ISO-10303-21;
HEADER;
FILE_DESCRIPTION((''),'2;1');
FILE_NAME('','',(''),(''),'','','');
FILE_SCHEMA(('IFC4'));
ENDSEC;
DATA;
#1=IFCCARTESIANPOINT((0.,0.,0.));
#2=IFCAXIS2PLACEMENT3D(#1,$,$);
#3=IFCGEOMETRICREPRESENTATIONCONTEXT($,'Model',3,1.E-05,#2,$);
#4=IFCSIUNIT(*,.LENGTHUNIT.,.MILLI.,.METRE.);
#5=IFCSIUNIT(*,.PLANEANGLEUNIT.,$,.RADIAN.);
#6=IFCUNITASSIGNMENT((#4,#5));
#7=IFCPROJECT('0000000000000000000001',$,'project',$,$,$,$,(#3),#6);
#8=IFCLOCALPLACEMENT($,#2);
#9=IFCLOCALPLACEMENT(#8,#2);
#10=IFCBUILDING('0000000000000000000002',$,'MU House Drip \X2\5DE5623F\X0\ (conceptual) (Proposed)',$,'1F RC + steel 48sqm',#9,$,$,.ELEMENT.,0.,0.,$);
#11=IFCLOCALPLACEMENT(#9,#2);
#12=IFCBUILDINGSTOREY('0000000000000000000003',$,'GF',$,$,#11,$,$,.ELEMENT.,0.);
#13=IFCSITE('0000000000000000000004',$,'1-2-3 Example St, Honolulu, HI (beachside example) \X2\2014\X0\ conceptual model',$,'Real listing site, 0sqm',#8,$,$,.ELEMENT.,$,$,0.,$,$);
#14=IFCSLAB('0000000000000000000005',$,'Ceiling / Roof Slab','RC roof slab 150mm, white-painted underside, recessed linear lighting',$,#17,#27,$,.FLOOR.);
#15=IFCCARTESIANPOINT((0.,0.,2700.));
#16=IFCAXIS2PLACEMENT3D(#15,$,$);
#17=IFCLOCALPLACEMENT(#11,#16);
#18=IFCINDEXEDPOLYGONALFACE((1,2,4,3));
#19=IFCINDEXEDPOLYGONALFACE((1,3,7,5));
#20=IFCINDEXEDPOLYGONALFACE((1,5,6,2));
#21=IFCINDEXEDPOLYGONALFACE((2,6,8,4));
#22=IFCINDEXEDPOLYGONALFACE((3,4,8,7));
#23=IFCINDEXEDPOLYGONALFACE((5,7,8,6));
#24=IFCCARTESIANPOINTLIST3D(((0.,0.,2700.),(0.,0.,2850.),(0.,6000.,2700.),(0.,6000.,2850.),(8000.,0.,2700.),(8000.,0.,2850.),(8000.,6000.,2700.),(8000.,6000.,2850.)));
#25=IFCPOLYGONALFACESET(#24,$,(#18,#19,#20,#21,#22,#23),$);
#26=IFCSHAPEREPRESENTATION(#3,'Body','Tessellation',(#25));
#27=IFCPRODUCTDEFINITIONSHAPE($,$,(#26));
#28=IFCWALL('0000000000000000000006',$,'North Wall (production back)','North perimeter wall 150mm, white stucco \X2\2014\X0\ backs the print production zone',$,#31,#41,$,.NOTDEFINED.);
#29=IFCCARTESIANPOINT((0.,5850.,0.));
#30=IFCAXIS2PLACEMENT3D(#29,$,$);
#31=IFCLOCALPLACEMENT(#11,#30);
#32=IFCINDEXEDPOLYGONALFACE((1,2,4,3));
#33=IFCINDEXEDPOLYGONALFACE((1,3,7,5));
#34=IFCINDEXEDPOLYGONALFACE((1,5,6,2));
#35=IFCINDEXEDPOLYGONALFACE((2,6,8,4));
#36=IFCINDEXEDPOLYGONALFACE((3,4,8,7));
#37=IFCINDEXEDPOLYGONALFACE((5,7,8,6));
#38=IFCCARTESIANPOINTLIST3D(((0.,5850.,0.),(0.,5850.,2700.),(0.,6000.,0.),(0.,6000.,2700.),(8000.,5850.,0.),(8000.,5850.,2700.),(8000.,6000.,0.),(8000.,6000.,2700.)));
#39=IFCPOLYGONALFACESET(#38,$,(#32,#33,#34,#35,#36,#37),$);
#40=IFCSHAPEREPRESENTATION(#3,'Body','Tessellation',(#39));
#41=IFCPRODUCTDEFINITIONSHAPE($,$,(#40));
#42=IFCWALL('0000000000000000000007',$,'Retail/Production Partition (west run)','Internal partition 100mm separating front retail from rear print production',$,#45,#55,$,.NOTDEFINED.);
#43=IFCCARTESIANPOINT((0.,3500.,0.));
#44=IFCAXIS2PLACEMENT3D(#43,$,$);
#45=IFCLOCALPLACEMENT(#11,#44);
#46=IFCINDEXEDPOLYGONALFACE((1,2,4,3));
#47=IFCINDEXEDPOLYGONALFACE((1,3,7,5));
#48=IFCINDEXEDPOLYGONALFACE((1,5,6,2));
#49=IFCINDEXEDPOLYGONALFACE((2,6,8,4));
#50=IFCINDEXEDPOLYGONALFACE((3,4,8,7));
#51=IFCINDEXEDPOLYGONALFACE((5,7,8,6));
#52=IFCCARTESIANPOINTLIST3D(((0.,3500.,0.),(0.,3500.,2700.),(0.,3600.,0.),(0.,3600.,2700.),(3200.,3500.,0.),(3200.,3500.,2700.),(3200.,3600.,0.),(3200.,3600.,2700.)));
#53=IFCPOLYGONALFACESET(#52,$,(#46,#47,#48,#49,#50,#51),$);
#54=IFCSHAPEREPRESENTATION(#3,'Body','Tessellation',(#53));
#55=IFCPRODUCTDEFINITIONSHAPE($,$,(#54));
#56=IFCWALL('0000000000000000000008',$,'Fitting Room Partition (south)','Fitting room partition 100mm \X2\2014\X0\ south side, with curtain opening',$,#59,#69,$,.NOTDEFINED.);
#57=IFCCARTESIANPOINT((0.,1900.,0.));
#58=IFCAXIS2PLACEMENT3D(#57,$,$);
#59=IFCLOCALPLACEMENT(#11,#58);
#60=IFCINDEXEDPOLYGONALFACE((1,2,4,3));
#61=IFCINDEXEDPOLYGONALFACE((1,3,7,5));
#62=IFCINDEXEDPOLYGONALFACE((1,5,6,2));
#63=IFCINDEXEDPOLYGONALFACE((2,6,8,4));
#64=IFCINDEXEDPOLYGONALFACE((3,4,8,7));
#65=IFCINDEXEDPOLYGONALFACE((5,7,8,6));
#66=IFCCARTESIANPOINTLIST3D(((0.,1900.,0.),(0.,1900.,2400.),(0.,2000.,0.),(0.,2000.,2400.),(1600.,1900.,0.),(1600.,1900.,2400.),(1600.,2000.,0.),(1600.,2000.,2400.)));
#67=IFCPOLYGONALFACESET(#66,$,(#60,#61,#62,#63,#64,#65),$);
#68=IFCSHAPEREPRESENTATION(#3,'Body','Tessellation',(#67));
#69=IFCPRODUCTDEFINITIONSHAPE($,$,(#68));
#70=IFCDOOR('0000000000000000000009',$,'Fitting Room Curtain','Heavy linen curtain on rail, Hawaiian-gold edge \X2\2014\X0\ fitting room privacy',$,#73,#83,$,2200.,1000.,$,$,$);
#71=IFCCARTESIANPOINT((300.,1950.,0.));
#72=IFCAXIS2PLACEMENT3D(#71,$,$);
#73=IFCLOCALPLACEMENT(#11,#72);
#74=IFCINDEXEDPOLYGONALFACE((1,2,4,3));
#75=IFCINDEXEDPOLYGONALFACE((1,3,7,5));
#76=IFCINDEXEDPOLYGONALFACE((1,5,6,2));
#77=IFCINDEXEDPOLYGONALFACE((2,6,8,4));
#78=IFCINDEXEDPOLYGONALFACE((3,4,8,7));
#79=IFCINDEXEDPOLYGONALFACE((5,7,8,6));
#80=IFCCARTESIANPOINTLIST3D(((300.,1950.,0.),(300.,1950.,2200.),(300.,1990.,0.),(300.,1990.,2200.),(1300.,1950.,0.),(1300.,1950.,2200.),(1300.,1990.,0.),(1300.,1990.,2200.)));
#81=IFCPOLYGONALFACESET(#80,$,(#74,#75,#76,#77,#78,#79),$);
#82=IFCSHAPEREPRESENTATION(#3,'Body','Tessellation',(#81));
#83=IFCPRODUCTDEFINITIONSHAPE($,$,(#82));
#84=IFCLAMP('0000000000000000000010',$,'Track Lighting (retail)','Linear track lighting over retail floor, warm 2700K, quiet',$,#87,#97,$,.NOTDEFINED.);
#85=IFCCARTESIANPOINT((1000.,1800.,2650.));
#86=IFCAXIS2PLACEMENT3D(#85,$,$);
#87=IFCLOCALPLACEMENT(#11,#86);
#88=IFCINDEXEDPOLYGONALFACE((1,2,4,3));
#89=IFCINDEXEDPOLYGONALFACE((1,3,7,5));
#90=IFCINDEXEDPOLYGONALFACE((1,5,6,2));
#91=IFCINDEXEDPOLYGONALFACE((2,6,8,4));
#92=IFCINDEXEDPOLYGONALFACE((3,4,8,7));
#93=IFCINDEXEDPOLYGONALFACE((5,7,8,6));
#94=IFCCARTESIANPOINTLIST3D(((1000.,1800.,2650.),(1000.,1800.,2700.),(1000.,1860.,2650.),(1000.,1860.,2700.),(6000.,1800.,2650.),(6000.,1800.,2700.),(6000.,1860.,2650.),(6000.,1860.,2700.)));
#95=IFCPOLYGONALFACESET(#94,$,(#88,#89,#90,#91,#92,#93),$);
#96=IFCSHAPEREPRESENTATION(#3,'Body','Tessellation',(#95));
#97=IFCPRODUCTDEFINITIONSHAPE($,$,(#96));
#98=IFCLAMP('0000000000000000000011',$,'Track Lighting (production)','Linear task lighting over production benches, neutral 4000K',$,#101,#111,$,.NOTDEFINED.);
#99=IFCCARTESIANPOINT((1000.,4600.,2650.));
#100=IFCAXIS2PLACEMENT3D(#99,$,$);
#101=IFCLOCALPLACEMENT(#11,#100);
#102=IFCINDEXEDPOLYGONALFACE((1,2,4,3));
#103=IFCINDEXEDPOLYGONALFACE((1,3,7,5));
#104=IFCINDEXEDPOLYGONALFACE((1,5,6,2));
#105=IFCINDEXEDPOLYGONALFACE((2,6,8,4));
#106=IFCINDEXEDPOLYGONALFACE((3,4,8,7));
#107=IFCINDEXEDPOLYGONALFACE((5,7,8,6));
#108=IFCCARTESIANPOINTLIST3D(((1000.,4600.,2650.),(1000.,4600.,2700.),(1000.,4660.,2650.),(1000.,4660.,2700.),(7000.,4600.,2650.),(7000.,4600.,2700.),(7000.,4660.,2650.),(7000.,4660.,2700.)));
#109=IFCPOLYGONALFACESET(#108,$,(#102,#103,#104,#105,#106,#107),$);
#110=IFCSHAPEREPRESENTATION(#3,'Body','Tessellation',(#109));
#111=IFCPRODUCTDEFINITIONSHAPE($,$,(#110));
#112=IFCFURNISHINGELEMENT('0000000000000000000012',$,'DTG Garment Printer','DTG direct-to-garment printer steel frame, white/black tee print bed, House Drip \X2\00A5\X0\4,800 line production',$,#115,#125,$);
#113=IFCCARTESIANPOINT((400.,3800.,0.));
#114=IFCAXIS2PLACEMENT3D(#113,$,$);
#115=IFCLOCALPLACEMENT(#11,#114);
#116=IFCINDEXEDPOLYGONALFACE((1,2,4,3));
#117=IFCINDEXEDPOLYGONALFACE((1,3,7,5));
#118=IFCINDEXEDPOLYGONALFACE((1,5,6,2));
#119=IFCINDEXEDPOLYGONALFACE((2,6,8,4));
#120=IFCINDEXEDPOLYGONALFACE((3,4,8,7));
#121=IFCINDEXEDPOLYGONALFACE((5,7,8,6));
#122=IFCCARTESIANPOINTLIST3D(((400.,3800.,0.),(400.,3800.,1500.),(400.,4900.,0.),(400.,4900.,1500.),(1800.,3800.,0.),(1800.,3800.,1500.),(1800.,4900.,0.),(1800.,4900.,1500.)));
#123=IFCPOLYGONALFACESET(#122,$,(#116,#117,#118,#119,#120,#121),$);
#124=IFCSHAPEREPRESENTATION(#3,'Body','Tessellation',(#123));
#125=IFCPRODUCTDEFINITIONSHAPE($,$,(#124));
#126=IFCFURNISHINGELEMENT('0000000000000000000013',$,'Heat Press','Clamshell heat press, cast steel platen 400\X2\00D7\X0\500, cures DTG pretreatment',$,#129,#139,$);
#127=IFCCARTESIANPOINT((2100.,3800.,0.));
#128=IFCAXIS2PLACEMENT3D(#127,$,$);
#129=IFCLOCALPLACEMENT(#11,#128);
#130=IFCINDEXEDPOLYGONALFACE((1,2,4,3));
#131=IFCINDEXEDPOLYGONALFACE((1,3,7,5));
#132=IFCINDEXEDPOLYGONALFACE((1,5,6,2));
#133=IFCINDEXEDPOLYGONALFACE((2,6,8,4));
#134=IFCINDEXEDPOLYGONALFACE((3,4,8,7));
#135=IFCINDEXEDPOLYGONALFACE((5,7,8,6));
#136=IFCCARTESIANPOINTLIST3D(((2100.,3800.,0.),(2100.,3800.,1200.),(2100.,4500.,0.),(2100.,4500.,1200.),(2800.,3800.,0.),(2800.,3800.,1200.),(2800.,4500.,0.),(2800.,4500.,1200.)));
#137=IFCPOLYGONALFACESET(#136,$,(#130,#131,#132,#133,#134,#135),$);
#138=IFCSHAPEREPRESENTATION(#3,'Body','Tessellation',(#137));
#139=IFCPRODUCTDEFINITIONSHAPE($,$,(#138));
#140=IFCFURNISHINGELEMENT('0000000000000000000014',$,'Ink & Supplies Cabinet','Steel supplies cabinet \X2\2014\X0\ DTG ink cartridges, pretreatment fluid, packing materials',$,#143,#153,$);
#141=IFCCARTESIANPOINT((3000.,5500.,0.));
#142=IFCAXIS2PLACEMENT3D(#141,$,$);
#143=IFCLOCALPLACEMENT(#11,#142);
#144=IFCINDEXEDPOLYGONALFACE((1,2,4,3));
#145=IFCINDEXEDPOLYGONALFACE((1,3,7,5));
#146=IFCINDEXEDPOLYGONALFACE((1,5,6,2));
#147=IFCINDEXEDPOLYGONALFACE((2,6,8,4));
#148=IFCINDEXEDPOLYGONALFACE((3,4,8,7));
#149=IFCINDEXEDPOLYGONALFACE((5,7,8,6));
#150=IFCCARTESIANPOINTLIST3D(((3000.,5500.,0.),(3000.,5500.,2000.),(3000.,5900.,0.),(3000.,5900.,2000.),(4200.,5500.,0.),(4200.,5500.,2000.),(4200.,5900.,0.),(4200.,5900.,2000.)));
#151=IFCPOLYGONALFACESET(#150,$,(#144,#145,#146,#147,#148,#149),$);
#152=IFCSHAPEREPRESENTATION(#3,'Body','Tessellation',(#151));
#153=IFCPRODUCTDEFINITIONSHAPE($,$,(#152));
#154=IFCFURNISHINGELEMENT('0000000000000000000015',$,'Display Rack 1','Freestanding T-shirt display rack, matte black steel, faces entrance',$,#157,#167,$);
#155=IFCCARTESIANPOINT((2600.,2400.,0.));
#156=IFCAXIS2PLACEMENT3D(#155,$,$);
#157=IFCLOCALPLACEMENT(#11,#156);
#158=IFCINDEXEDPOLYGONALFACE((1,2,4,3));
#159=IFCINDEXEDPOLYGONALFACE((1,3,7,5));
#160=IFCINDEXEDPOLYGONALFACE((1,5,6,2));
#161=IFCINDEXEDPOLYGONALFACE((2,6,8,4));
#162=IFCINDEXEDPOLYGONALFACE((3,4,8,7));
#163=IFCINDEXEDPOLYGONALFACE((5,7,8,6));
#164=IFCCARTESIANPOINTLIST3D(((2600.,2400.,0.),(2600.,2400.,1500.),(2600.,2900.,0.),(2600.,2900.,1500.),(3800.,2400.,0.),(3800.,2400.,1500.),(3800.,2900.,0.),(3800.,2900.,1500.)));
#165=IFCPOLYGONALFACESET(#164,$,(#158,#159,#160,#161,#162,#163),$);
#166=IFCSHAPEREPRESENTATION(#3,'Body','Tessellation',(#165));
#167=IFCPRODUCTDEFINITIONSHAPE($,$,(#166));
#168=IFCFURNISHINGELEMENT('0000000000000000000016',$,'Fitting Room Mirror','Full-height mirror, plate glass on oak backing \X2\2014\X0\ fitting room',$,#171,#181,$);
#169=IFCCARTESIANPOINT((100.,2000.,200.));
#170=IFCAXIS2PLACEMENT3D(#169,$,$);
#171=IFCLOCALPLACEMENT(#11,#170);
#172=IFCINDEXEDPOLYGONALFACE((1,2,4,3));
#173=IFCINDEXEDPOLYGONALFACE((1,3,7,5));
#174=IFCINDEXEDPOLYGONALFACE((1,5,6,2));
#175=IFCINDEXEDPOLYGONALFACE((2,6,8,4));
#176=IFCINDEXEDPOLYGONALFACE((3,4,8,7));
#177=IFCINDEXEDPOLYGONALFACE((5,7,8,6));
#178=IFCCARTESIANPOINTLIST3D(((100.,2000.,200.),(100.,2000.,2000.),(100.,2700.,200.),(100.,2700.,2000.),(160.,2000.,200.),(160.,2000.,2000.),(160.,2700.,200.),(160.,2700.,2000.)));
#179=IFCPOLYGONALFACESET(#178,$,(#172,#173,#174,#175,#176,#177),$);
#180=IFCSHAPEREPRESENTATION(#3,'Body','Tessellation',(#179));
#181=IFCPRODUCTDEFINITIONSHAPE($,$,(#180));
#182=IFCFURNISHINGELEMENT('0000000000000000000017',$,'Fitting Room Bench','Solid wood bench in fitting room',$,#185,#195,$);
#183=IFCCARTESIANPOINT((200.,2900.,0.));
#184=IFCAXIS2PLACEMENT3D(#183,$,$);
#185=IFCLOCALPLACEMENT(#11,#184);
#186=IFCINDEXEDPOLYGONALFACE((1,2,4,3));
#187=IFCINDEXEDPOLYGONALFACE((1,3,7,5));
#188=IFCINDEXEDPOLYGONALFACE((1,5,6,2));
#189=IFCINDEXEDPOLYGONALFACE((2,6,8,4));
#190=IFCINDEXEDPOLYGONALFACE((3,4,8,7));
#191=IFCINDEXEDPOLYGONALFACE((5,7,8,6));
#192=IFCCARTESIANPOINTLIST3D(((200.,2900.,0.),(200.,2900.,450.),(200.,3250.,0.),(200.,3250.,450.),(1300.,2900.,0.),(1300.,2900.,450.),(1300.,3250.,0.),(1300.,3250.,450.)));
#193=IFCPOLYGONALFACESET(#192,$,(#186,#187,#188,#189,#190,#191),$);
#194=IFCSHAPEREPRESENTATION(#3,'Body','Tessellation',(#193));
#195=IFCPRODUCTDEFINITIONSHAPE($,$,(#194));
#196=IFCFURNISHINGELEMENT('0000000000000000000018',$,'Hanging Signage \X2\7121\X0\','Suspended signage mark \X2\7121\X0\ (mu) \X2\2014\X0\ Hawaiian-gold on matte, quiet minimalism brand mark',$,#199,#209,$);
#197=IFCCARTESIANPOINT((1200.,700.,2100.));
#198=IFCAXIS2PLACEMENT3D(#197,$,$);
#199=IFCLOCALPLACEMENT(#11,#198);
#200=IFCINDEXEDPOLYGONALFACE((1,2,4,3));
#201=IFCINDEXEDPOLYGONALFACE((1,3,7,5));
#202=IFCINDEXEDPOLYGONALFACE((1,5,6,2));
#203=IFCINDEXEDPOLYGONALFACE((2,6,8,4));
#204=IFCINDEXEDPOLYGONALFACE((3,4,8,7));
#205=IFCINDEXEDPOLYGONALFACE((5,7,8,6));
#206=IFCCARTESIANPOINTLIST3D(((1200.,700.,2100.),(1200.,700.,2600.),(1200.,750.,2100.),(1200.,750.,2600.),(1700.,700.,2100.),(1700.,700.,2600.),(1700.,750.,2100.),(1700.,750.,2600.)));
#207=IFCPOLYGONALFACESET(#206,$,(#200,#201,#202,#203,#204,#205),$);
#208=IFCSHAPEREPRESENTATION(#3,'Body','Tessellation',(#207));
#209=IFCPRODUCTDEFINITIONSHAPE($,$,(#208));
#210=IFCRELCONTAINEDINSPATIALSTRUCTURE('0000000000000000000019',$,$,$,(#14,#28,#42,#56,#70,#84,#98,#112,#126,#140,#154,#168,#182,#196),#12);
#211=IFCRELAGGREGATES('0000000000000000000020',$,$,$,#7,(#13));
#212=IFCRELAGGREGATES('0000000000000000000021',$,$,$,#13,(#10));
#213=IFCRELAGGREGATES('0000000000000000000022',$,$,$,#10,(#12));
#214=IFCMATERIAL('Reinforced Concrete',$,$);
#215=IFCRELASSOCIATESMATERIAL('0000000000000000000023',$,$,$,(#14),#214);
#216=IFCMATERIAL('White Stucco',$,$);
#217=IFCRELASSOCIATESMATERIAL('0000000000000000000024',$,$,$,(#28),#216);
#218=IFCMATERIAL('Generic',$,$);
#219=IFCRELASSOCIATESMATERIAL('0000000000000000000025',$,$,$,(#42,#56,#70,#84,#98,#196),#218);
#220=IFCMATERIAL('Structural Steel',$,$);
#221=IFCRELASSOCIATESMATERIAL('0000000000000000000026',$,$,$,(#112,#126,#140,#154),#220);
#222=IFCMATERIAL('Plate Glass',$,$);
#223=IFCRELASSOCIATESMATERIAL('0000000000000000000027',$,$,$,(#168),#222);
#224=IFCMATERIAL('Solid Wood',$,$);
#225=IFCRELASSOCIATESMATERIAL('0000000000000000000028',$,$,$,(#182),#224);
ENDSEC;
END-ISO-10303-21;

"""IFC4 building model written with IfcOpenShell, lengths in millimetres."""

from ifc_helpers import new_model, si_unit, frame, frame_2d, origin, place, context, project, spatial, rectangle, extrude, material, element, fill, save


model = new_model("IFC4")

# Units and contexts
model_context = context("Model", 3, precision=1e-05, world=origin())
ifc_project = project(units=[si_unit("LENGTHUNIT", "METRE", prefix="MILLI"), si_unit("PLANEANGLEUNIT", "RADIAN")], contexts=[model_context])

# Site, building, storey
site_placement = place(None, origin())
site = spatial("IfcSite", under=ifc_project, at=site_placement, Name="1-2-3 Example St, Honolulu, HI (beachside example) — conceptual model", ObjectType="Real listing site, 0sqm", CompositionType="ELEMENT", RefElevation=0.0)
building_placement = place(site_placement, origin())
building = spatial("IfcBuilding", under=site, at=building_placement, Name="MU House Drip 工房 (conceptual) (Proposed)", ObjectType="1F RC + steel 48sqm", CompositionType="ELEMENT", ElevationOfRefHeight=0.0, ElevationOfTerrain=0.0)
storey_placement = place(building_placement, origin())
storey = spatial("IfcBuildingStorey", under=building, at=storey_placement, Name="GF", CompositionType="ELEMENT", Elevation=0.0)

# Slab
ifc_material_1 = material(Name="Reinforced Concrete")
slab_1_placement = place(storey_placement, frame((0.0, 0.0, 2700.0)))
element("IfcSlab", 1, at=slab_1_placement, inside=storey, material=ifc_material_1, Name="Ceiling / Roof Slab", Description="RC roof slab 150mm, white-painted underside, recessed linear lighting", PredefinedType="FLOOR", context=model_context, shape_type="SweptSolid", body=[
    extrude(rectangle(XDim=8000.0, YDim=6000.0, at=frame_2d((4000.0, 3000.0))), frame((0.0, 0.0, 2700.0)), (0.0, 0.0, 1.0), 150.0),
])

# Shared definitions
ifc_material_2 = material(Name="White Stucco")
ifc_material_3 = material(Name="Plate Glass")

# Walls
wall_1_placement = place(storey_placement, frame((0.0, 5850.0, 0.0)))
element("IfcWall", 2, at=wall_1_placement, inside=storey, material=ifc_material_2, Name="North Wall (production back)", Description="North perimeter wall 150mm, white stucco — backs the print production zone", PredefinedType="NOTDEFINED", context=model_context, shape_type="SweptSolid", body=[
    extrude(rectangle(XDim=8000.0, YDim=150.0, at=frame_2d((4000.0, 75.0))), frame((0.0, 5850.0, 0.0)), (0.0, 0.0, 1.0), 2700.0),
])
ifc_material_4 = material(Name="Generic")
wall_2_placement = place(storey_placement, frame((0.0, 3500.0, 0.0)))
element("IfcWall", 3, at=wall_2_placement, inside=storey, material=ifc_material_4, Name="Retail/Production Partition (west run)", Description="Internal partition 100mm separating front retail from rear print production", PredefinedType="NOTDEFINED", context=model_context, shape_type="SweptSolid", body=[
    extrude(rectangle(XDim=3200.0, YDim=100.0, at=frame_2d((1600.0, 50.0))), frame((0.0, 3500.0, 0.0)), (0.0, 0.0, 1.0), 2700.0),
])

# Wall, opening, door
wall_3_placement = place(storey_placement, frame((0.0, 1900.0, 0.0)))
wall_3 = element("IfcWall", 4, at=wall_3_placement, inside=storey, material=ifc_material_4, Name="Fitting Room Partition (south)", Description="Fitting room partition 100mm — south side, with curtain opening", PredefinedType="NOTDEFINED", context=model_context, shape_type="SweptSolid", body=[
    extrude(rectangle(XDim=1600.0, YDim=100.0, at=frame_2d((800.0, 50.0))), frame((0.0, 1900.0, 0.0)), (0.0, 0.0, 1.0), 2400.0),
])
opening_1_placement = place(storey_placement, frame((300.0, 1950.0, 0.0)))
opening_1 = element("IfcOpeningElement", 5, at=opening_1_placement, cuts=wall_3, PredefinedType="NOTDEFINED", context=model_context, shape_type="SweptSolid", body=[
    extrude(rectangle(XDim=1000.0, YDim=40.0, at=frame_2d((500.0, 20.0))), frame((300.0, 1950.0, 0.0)), (0.0, 0.0, 1.0), 2200.0),
])
door_1_placement = place(storey_placement, frame((300.0, 1950.0, 0.0)))
door_1 = element("IfcDoor", 6, at=door_1_placement, inside=storey, material=ifc_material_4, Name="Fitting Room Curtain", Description="Heavy linen curtain on rail, Hawaiian-gold edge — fitting room privacy", OverallHeight=2200.0, OverallWidth=1000.0, context=model_context, shape_type="SweptSolid", body=[
    extrude(rectangle(XDim=1000.0, YDim=40.0, at=frame_2d((500.0, 20.0))), frame((300.0, 1950.0, 0.0)), (0.0, 0.0, 1.0), 2200.0),
])
fill(opening_1, door_1)

# Lamps
lamp_1_placement = place(storey_placement, frame((1000.0, 1800.0, 2650.0)))
element("IfcLamp", 7, at=lamp_1_placement, inside=storey, material=ifc_material_4, Name="Track Lighting (retail)", Description="Linear track lighting over retail floor, warm 2700K, quiet", PredefinedType="NOTDEFINED", context=model_context, shape_type="SweptSolid", body=[
    extrude(rectangle(XDim=5000.0, YDim=60.0, at=frame_2d((2500.0, 30.0))), frame((1000.0, 1800.0, 2650.0)), (0.0, 0.0, 1.0), 50.0),
])
lamp_2_placement = place(storey_placement, frame((1000.0, 4600.0, 2650.0)))
element("IfcLamp", 8, at=lamp_2_placement, inside=storey, material=ifc_material_4, Name="Track Lighting (production)", Description="Linear task lighting over production benches, neutral 4000K", PredefinedType="NOTDEFINED", context=model_context, shape_type="SweptSolid", body=[
    extrude(rectangle(XDim=6000.0, YDim=60.0, at=frame_2d((3000.0, 30.0))), frame((1000.0, 4600.0, 2650.0)), (0.0, 0.0, 1.0), 50.0),
])

# Furnishing elements
ifc_material_5 = material(Name="Structural Steel")
furnishing_1_placement = place(storey_placement, frame((400.0, 3800.0, 0.0)))
element("IfcFurnishingElement", 9, at=furnishing_1_placement, inside=storey, material=ifc_material_5, Name="DTG Garment Printer", Description="DTG direct-to-garment printer steel frame, white/black tee print bed, House Drip ¥4,800 line production", context=model_context, shape_type="SweptSolid", body=[
    extrude(rectangle(XDim=1400.0, YDim=1100.0, at=frame_2d((700.0, 550.0))), frame((400.0, 3800.0, 0.0)), (0.0, 0.0, 1.0), 1500.0),
])
furnishing_2_placement = place(storey_placement, frame((2100.0, 3800.0, 0.0)))
element("IfcFurnishingElement", 10, at=furnishing_2_placement, inside=storey, material=ifc_material_5, Name="Heat Press", Description="Clamshell heat press, cast steel platen 400×500, cures DTG pretreatment", context=model_context, shape_type="SweptSolid", body=[
    extrude(rectangle(XDim=700.0, YDim=700.0, at=frame_2d((350.0, 350.0))), frame((2100.0, 3800.0, 0.0)), (0.0, 0.0, 1.0), 1200.0),
])
furnishing_3_placement = place(storey_placement, frame((3000.0, 5500.0, 0.0)))
element("IfcFurnishingElement", 11, at=furnishing_3_placement, inside=storey, material=ifc_material_5, Name="Ink & Supplies Cabinet", Description="Steel supplies cabinet — DTG ink cartridges, pretreatment fluid, packing materials", context=model_context, shape_type="SweptSolid", body=[
    extrude(rectangle(XDim=1200.0, YDim=400.0, at=frame_2d((600.0, 200.0))), frame((3000.0, 5500.0, 0.0)), (0.0, 0.0, 1.0), 2000.0),
])
furnishing_4_placement = place(storey_placement, frame((2600.0, 2400.0, 0.0)))
element("IfcFurnishingElement", 12, at=furnishing_4_placement, inside=storey, material=ifc_material_5, Name="Display Rack 1", Description="Freestanding T-shirt display rack, matte black steel, faces entrance", context=model_context, shape_type="SweptSolid", body=[
    extrude(rectangle(XDim=1200.0, YDim=500.0, at=frame_2d((600.0, 250.0))), frame((2600.0, 2400.0, 0.0)), (0.0, 0.0, 1.0), 1500.0),
])
furnishing_5_placement = place(storey_placement, frame((100.0, 2000.0, 200.0)))
element("IfcFurnishingElement", 13, at=furnishing_5_placement, inside=storey, material=ifc_material_3, Name="Fitting Room Mirror", Description="Full-height mirror, plate glass on oak backing — fitting room", context=model_context, shape_type="SweptSolid", body=[
    extrude(rectangle(XDim=60.0, YDim=700.0, at=frame_2d((30.0, 350.0))), frame((100.0, 2000.0, 200.0)), (0.0, 0.0, 1.0), 1800.0),
])
ifc_material_6 = material(Name="Solid Wood")
furnishing_6_placement = place(storey_placement, frame((200.0, 2900.0, 0.0)))
element("IfcFurnishingElement", 14, at=furnishing_6_placement, inside=storey, material=ifc_material_6, Name="Fitting Room Bench", Description="Solid wood bench in fitting room", context=model_context, shape_type="SweptSolid", body=[
    extrude(rectangle(XDim=1100.0, YDim=350.0, at=frame_2d((550.0, 175.0))), frame((200.0, 2900.0, 0.0)), (0.0, 0.0, 1.0), 450.0),
])
furnishing_7_placement = place(storey_placement, frame((1200.0, 700.0, 2100.0)))
element("IfcFurnishingElement", 15, at=furnishing_7_placement, inside=storey, material=ifc_material_4, Name="Hanging Signage 無", Description="Suspended signage mark 無 (mu) — Hawaiian-gold on matte, quiet minimalism brand mark", context=model_context, shape_type="SweptSolid", body=[
    extrude(rectangle(XDim=500.0, YDim=50.0, at=frame_2d((250.0, 25.0))), frame((1200.0, 700.0, 2100.0)), (0.0, 0.0, 1.0), 500.0),
])

save(model, "model.ifc")
